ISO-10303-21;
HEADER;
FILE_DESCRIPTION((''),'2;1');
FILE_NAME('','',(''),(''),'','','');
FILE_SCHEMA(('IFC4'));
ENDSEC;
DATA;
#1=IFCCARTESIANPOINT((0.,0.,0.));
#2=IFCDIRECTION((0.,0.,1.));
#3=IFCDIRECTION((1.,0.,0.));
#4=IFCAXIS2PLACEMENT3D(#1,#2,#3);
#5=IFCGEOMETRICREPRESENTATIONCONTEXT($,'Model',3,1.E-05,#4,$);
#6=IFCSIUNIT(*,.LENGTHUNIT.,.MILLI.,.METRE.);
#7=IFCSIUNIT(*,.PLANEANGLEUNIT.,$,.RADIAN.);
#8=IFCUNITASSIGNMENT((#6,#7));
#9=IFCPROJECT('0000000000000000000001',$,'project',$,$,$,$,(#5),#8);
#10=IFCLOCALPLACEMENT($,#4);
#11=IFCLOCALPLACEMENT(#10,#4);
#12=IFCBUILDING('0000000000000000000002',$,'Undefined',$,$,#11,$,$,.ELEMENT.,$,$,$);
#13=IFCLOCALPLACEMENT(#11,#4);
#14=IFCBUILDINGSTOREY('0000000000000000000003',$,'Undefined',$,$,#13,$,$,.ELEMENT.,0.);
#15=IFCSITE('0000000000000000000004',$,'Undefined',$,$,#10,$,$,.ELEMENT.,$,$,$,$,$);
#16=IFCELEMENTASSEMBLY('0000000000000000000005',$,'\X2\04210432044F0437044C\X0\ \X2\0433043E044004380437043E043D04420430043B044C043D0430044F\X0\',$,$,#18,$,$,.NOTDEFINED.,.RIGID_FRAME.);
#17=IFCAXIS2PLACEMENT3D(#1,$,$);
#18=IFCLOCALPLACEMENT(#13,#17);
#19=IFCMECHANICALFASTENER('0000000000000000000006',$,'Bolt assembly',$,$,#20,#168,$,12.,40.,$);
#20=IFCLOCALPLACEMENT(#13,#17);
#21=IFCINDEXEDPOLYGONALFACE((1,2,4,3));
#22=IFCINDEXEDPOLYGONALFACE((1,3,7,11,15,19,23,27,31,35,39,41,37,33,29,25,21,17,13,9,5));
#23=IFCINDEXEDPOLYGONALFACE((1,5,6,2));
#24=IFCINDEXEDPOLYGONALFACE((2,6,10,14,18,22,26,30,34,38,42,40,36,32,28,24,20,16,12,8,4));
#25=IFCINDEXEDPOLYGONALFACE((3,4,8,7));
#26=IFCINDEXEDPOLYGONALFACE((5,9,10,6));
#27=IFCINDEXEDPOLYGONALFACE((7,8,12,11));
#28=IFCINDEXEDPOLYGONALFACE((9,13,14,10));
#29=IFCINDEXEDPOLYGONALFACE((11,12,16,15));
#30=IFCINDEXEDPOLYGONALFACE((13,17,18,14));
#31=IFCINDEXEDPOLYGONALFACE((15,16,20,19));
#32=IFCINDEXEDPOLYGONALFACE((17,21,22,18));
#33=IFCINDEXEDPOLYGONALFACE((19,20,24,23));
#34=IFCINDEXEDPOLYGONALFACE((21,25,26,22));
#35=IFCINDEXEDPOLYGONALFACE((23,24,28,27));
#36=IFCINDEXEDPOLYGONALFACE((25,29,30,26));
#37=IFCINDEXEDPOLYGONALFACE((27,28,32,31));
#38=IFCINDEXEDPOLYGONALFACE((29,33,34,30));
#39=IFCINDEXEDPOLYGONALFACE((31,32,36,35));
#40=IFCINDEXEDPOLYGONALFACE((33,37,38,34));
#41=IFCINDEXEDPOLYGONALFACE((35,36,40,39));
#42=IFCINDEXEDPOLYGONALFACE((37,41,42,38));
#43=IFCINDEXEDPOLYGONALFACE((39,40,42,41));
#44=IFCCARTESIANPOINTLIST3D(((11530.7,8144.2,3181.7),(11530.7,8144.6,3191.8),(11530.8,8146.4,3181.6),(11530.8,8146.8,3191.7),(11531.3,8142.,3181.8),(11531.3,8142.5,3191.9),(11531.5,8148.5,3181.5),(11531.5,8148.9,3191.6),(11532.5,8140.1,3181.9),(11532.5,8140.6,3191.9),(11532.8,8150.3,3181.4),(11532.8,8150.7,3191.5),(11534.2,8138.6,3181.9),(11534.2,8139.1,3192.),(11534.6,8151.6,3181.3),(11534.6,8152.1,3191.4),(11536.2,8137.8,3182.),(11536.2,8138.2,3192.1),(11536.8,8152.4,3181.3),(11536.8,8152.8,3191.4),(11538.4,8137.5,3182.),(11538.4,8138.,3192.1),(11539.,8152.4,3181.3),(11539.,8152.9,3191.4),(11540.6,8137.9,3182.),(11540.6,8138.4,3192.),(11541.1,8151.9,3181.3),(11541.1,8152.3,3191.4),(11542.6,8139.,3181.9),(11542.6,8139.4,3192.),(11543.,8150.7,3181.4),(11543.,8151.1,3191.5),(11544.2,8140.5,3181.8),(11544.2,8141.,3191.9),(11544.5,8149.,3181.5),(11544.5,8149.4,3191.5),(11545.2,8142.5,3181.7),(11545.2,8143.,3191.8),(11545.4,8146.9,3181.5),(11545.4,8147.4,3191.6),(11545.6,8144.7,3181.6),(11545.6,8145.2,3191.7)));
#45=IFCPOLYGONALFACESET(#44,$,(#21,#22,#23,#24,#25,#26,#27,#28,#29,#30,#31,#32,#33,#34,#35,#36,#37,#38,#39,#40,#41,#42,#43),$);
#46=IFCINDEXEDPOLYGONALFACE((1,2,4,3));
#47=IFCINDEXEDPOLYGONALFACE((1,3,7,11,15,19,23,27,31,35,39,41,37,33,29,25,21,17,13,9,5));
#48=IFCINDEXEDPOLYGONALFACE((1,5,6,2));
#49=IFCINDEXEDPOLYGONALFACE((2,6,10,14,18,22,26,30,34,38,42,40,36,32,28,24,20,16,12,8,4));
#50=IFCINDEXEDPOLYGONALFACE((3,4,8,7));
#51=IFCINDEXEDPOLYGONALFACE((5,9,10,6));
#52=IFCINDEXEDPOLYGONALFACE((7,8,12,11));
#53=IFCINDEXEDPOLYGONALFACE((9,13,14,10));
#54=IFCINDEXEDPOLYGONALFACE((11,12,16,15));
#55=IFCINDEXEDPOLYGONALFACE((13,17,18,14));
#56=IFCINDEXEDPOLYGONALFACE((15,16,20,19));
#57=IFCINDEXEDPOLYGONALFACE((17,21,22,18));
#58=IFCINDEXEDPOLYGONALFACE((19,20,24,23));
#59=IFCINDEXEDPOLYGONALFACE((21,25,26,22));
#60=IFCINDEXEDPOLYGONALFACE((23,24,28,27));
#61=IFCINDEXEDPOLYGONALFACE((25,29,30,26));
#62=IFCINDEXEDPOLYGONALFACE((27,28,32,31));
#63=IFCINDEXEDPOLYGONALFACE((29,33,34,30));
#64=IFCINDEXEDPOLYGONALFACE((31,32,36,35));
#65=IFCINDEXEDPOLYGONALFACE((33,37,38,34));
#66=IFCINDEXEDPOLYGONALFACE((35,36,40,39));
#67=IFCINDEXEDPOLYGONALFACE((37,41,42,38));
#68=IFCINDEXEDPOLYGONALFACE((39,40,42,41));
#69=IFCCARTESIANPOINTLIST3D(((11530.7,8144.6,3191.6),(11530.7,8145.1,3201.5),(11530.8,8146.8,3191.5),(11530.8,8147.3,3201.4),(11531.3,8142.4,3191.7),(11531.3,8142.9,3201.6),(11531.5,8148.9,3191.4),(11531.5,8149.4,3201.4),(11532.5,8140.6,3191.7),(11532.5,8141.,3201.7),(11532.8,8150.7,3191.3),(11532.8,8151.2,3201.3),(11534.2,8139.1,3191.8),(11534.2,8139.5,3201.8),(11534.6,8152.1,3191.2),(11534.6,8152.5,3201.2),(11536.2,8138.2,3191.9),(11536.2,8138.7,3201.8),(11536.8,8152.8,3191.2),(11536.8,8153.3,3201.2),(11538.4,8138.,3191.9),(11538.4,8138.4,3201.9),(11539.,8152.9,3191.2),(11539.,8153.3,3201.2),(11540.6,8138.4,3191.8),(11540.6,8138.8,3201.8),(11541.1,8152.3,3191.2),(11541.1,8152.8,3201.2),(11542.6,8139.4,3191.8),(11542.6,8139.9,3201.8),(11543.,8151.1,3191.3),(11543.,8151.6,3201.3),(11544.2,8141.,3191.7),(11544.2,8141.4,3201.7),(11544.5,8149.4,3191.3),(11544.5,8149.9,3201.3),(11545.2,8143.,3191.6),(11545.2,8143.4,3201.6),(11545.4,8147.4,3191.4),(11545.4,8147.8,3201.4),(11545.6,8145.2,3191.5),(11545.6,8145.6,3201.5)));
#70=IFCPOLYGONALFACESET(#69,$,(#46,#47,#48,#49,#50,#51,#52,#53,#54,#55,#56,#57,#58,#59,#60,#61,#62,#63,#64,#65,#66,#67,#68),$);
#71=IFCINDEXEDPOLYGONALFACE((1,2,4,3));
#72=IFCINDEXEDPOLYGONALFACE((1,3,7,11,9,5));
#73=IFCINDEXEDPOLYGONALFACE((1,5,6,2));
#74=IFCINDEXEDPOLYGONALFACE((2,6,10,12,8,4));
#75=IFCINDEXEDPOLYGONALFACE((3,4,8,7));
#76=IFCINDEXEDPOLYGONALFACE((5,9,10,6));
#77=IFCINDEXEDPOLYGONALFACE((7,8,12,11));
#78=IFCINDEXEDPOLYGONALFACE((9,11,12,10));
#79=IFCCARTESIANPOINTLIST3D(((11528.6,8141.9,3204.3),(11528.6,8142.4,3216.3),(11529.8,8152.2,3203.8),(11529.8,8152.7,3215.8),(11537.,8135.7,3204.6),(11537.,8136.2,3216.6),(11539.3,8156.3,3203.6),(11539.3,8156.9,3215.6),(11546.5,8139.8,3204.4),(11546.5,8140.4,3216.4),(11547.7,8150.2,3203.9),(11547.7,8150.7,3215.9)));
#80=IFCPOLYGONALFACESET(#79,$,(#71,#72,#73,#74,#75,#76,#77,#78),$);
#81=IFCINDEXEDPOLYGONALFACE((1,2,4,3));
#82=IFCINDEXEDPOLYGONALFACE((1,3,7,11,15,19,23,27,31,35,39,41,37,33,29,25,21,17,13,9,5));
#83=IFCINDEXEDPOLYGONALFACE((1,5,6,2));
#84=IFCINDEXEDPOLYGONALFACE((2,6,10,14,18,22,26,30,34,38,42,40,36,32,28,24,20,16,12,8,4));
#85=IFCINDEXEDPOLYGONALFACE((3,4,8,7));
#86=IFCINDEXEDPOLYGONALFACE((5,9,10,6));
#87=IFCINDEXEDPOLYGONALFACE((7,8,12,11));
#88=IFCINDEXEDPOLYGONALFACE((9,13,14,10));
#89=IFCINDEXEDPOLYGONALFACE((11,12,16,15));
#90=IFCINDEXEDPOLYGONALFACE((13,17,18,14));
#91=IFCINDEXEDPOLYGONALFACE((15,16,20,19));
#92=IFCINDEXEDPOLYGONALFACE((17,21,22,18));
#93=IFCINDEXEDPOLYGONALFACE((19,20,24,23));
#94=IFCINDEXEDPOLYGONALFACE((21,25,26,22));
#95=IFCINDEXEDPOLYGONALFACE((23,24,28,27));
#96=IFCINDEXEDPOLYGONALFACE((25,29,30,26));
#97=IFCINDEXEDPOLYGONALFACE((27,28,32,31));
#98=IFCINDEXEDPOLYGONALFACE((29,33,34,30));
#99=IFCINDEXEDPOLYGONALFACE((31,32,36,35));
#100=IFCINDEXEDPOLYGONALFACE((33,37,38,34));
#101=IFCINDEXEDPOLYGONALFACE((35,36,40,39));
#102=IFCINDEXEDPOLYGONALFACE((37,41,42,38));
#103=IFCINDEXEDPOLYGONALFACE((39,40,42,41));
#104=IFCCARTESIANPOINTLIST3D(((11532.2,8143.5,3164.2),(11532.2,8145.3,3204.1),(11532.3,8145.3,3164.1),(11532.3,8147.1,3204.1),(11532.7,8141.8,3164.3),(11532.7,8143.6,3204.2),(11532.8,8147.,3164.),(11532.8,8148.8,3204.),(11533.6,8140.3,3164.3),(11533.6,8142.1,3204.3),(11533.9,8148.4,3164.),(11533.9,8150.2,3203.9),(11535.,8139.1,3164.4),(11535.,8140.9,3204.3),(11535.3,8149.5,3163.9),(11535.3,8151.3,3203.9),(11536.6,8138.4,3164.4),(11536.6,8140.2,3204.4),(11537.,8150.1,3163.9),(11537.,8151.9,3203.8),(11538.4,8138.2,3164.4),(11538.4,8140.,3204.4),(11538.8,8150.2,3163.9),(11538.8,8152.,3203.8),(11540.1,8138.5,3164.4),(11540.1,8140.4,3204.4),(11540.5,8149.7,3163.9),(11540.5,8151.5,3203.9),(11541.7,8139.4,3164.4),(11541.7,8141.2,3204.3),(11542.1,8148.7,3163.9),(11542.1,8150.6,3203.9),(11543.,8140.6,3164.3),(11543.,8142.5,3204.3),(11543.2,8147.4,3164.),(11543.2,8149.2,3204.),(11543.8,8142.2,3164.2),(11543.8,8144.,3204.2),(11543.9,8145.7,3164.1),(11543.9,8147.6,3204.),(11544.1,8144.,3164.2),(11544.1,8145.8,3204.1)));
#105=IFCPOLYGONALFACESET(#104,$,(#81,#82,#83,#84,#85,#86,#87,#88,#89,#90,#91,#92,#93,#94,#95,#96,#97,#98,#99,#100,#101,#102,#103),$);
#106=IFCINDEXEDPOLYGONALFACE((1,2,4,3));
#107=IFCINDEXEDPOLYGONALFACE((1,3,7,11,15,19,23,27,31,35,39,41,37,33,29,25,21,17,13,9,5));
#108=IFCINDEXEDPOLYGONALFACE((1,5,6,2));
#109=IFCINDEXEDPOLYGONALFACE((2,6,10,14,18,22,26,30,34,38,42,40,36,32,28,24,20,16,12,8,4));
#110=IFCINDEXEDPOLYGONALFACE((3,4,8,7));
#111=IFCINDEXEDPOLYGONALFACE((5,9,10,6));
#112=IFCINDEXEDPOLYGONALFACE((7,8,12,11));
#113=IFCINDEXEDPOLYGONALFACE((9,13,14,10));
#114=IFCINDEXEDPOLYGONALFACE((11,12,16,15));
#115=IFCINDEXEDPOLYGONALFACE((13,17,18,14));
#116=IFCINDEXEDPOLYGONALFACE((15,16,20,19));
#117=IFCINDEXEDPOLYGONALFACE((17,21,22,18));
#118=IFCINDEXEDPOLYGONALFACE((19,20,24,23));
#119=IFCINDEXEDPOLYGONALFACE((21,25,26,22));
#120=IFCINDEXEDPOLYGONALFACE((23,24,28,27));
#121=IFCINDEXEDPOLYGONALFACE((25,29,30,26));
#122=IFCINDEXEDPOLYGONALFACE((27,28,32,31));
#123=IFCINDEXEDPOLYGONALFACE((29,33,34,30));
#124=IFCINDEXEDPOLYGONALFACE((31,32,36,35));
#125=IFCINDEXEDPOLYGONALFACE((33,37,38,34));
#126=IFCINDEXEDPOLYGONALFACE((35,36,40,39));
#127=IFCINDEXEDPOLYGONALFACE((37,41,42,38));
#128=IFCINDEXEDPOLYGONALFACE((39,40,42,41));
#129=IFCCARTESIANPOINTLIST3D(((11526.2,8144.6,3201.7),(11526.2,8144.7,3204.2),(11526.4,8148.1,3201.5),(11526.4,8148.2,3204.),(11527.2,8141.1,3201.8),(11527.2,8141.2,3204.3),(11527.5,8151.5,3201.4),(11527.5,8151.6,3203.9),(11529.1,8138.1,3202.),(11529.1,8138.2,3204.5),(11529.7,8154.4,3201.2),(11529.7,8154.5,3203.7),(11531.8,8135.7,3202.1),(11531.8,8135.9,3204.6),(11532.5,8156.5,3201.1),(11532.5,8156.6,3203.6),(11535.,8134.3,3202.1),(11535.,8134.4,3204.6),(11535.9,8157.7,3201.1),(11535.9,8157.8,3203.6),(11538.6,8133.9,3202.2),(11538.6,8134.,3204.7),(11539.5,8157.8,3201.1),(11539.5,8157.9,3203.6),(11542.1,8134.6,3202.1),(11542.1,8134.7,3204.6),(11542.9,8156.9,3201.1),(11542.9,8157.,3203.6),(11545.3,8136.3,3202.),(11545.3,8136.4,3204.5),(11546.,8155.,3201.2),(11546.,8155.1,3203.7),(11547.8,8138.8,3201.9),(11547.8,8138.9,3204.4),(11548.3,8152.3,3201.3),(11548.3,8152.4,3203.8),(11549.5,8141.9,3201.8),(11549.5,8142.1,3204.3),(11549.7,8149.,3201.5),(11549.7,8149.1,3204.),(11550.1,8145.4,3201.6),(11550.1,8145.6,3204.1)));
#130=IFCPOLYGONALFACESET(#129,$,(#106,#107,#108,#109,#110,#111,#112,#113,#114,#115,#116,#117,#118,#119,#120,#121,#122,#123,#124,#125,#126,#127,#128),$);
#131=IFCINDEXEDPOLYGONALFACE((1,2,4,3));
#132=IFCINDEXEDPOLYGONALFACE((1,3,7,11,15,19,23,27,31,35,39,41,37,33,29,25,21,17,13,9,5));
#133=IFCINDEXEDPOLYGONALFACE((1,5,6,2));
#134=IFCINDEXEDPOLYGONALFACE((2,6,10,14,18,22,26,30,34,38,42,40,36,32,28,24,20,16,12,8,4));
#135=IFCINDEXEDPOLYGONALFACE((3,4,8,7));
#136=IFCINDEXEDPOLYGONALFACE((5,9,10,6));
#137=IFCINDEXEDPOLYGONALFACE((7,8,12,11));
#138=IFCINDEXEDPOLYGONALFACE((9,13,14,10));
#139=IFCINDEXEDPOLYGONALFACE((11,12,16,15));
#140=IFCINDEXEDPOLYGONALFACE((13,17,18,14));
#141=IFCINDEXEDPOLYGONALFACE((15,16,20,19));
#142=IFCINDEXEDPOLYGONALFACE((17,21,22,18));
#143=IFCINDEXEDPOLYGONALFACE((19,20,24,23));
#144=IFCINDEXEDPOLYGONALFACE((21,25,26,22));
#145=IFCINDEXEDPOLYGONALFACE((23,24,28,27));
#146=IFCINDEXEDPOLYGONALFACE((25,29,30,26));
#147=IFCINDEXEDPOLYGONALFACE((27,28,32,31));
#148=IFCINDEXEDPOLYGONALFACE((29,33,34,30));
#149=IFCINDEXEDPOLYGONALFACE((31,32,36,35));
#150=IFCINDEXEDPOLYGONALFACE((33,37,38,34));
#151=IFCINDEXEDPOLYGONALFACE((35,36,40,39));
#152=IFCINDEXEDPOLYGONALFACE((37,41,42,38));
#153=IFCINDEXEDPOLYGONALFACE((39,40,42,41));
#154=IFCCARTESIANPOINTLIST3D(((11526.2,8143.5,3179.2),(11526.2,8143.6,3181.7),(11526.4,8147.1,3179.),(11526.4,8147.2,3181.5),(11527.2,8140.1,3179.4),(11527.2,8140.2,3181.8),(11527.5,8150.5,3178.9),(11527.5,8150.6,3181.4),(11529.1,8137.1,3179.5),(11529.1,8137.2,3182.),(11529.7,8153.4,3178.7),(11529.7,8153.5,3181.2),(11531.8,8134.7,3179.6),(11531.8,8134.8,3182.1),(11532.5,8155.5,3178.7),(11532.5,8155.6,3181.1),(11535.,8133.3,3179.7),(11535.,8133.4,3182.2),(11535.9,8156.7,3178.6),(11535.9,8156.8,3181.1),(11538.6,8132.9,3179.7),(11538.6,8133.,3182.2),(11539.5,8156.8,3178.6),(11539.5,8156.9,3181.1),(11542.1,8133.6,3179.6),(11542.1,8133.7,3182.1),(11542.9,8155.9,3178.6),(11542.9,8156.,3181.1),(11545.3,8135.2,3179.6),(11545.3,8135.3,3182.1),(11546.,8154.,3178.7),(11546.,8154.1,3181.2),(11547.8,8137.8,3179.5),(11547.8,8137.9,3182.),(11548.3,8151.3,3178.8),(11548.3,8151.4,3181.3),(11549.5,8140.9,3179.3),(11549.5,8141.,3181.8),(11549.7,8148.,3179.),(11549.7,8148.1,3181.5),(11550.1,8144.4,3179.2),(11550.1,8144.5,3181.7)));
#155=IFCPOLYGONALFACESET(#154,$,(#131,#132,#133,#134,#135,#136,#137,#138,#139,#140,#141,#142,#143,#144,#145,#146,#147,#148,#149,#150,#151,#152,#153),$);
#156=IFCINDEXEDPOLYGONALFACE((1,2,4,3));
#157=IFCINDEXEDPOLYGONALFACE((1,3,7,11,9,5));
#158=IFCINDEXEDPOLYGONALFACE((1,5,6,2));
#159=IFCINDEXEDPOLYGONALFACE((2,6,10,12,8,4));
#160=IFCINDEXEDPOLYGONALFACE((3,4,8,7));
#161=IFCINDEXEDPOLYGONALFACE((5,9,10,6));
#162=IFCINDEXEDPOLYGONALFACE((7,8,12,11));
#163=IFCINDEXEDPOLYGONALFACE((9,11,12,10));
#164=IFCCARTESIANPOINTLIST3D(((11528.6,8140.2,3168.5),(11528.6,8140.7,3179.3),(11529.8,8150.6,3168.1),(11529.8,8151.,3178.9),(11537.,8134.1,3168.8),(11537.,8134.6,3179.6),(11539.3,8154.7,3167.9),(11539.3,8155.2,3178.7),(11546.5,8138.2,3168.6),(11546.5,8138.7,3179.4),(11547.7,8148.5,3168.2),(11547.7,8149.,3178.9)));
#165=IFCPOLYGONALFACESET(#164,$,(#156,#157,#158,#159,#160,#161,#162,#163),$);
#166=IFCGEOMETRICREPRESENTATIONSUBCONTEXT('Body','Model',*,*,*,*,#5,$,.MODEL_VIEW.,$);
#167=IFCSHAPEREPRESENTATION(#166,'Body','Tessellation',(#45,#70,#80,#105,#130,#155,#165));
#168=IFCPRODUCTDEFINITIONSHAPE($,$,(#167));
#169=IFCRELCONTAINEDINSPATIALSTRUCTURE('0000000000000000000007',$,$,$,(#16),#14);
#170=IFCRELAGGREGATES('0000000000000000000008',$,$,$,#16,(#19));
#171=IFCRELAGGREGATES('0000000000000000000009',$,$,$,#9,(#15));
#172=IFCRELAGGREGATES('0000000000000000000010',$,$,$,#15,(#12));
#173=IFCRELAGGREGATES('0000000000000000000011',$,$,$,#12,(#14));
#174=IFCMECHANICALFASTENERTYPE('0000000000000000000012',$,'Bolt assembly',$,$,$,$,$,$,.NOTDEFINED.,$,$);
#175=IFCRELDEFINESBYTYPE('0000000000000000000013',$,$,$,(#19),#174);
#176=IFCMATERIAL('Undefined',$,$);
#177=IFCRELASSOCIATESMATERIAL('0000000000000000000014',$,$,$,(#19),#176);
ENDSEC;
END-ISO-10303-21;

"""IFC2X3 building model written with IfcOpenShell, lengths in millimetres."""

from ifc_helpers import new_model, si_unit, frame, origin_with_axes, origin_2d_with_axis, place, context, subcontext, project, spatial, polyline, circle, outline, extrude, source, transform, mapped, material, type_object, element, aggregate, save


model = new_model("IFC2X3")

# Units and contexts
model_context = context("Model", 3, precision=1e-05, world=origin_with_axes())
body_context = subcontext(model_context, "Body", "Model", "MODEL_VIEW")
ifc_project = project(units=[si_unit("LENGTHUNIT", "METRE", prefix="MILLI"), si_unit("PLANEANGLEUNIT", "RADIAN")], contexts=[model_context])

# Site, building, storey
site_placement = place(None, origin_with_axes())
site = spatial("IfcSite", under=ifc_project, at=site_placement, Name="Undefined", CompositionType="ELEMENT")
building_placement = place(site_placement, origin_with_axes())
building = spatial("IfcBuilding", under=site, at=building_placement, Name="Undefined", CompositionType="ELEMENT")
storey_placement = place(building_placement, origin_with_axes())
storey = spatial("IfcBuildingStorey", under=building, at=storey_placement, Name="Undefined", CompositionType="ELEMENT", Elevation=0.0)

# Element assembly
assembly_1_placement = place(storey_placement, origin_with_axes())
assembly_1 = element("IfcElementAssembly", 1, at=assembly_1_placement, inside=storey, Name="Связь горизонтальная", AssemblyPlace="NOTDEFINED", PredefinedType="RIGID_FRAME")

# Mechanical fastener
ifc_material_1 = material(Name="Undefined")
mechanical_fastener_type = type_object("IfcMechanicalFastenerType", Name="Bolt assembly")
shared_shape_1 = source(origin_with_axes(), body_context, "Body", "SweptSolid", [
    extrude(circle(Radius=7.5, at=origin_2d_with_axis()), frame((0.0, -0.1, 0.0), z_axis=(0.0, 1.0, 0.0), x_axis=(1.0, 0.0, 0.0)), (0.0, 0.0, 1.0), 10.1),
    extrude(circle(Radius=7.5, at=origin_2d_with_axis()), frame((0.0, -9.9, 0.0), z_axis=(0.0, 1.0, 0.0), x_axis=(1.0, 0.0, 0.0)), (0.0, 0.0, 1.0), 10.0),
    extrude(outline(polyline([(10.4, 0.0), (5.2, 9.0), (-5.2, 9.0), (-10.4, 0.0), (-5.2, -9.0), (5.2, -9.0), (10.4, 0.0)])), frame((0.0, -24.5, 0.0), z_axis=(0.0, 1.0, 0.0), x_axis=(1.0, 0.0, 0.0)), (0.0, 0.0, 1.0), 12.0),
    extrude(circle(Radius=6.0, at=origin_2d_with_axis()), frame((0.0, -12.5, 0.0), z_axis=(0.0, 1.0, 0.0), x_axis=(1.0, 0.0, 0.0)), (0.0, 0.0, 1.0), 40.0),
    extrude(circle(Radius=12.0, at=origin_2d_with_axis()), frame((0.0, -12.5, 0.0), z_axis=(0.0, 1.0, 0.0), x_axis=(1.0, 0.0, 0.0)), (0.0, 0.0, 1.0), 2.5),
    extrude(circle(Radius=12.0, at=origin_2d_with_axis()), frame((0.0, 10.0, 0.0), z_axis=(0.0, 1.0, 0.0), x_axis=(1.0, 0.0, 0.0)), (0.0, 0.0, 1.0), 2.5),
    extrude(outline(polyline([(10.4, 0.0), (5.2, 9.0), (-5.2, 9.0), (-10.4, 0.0), (-5.2, -9.0), (5.2, -9.0), (10.4, 0.0)])), frame((0.0, 12.5, 0.0), z_axis=(0.0, 1.0, 0.0), x_axis=(1.0, 0.0, 0.0)), (0.0, 0.0, 1.0), 10.8),
])
mechanical_fastener_1_placement = place(assembly_1_placement, frame((11538.1, 8145.4, 3191.6), z_axis=(0.593795, 0.803786, -0.036536), x_axis=(0.804616, -0.593183, 0.026963)))
mechanical_fastener_1 = element("IfcMechanicalFastener", 2, at=mechanical_fastener_1_placement, type_object=mechanical_fastener_type, material=ifc_material_1, Name="Bolt assembly", NominalDiameter=12.0, NominalLength=40.0, context=body_context, shape_type="MappedRepresentation", body=[
    mapped(shared_shape_1, transform((0.0, 0.0, 0.0))),
])
aggregate(assembly_1, [mechanical_fastener_1])

save(model, "model.ifc")
